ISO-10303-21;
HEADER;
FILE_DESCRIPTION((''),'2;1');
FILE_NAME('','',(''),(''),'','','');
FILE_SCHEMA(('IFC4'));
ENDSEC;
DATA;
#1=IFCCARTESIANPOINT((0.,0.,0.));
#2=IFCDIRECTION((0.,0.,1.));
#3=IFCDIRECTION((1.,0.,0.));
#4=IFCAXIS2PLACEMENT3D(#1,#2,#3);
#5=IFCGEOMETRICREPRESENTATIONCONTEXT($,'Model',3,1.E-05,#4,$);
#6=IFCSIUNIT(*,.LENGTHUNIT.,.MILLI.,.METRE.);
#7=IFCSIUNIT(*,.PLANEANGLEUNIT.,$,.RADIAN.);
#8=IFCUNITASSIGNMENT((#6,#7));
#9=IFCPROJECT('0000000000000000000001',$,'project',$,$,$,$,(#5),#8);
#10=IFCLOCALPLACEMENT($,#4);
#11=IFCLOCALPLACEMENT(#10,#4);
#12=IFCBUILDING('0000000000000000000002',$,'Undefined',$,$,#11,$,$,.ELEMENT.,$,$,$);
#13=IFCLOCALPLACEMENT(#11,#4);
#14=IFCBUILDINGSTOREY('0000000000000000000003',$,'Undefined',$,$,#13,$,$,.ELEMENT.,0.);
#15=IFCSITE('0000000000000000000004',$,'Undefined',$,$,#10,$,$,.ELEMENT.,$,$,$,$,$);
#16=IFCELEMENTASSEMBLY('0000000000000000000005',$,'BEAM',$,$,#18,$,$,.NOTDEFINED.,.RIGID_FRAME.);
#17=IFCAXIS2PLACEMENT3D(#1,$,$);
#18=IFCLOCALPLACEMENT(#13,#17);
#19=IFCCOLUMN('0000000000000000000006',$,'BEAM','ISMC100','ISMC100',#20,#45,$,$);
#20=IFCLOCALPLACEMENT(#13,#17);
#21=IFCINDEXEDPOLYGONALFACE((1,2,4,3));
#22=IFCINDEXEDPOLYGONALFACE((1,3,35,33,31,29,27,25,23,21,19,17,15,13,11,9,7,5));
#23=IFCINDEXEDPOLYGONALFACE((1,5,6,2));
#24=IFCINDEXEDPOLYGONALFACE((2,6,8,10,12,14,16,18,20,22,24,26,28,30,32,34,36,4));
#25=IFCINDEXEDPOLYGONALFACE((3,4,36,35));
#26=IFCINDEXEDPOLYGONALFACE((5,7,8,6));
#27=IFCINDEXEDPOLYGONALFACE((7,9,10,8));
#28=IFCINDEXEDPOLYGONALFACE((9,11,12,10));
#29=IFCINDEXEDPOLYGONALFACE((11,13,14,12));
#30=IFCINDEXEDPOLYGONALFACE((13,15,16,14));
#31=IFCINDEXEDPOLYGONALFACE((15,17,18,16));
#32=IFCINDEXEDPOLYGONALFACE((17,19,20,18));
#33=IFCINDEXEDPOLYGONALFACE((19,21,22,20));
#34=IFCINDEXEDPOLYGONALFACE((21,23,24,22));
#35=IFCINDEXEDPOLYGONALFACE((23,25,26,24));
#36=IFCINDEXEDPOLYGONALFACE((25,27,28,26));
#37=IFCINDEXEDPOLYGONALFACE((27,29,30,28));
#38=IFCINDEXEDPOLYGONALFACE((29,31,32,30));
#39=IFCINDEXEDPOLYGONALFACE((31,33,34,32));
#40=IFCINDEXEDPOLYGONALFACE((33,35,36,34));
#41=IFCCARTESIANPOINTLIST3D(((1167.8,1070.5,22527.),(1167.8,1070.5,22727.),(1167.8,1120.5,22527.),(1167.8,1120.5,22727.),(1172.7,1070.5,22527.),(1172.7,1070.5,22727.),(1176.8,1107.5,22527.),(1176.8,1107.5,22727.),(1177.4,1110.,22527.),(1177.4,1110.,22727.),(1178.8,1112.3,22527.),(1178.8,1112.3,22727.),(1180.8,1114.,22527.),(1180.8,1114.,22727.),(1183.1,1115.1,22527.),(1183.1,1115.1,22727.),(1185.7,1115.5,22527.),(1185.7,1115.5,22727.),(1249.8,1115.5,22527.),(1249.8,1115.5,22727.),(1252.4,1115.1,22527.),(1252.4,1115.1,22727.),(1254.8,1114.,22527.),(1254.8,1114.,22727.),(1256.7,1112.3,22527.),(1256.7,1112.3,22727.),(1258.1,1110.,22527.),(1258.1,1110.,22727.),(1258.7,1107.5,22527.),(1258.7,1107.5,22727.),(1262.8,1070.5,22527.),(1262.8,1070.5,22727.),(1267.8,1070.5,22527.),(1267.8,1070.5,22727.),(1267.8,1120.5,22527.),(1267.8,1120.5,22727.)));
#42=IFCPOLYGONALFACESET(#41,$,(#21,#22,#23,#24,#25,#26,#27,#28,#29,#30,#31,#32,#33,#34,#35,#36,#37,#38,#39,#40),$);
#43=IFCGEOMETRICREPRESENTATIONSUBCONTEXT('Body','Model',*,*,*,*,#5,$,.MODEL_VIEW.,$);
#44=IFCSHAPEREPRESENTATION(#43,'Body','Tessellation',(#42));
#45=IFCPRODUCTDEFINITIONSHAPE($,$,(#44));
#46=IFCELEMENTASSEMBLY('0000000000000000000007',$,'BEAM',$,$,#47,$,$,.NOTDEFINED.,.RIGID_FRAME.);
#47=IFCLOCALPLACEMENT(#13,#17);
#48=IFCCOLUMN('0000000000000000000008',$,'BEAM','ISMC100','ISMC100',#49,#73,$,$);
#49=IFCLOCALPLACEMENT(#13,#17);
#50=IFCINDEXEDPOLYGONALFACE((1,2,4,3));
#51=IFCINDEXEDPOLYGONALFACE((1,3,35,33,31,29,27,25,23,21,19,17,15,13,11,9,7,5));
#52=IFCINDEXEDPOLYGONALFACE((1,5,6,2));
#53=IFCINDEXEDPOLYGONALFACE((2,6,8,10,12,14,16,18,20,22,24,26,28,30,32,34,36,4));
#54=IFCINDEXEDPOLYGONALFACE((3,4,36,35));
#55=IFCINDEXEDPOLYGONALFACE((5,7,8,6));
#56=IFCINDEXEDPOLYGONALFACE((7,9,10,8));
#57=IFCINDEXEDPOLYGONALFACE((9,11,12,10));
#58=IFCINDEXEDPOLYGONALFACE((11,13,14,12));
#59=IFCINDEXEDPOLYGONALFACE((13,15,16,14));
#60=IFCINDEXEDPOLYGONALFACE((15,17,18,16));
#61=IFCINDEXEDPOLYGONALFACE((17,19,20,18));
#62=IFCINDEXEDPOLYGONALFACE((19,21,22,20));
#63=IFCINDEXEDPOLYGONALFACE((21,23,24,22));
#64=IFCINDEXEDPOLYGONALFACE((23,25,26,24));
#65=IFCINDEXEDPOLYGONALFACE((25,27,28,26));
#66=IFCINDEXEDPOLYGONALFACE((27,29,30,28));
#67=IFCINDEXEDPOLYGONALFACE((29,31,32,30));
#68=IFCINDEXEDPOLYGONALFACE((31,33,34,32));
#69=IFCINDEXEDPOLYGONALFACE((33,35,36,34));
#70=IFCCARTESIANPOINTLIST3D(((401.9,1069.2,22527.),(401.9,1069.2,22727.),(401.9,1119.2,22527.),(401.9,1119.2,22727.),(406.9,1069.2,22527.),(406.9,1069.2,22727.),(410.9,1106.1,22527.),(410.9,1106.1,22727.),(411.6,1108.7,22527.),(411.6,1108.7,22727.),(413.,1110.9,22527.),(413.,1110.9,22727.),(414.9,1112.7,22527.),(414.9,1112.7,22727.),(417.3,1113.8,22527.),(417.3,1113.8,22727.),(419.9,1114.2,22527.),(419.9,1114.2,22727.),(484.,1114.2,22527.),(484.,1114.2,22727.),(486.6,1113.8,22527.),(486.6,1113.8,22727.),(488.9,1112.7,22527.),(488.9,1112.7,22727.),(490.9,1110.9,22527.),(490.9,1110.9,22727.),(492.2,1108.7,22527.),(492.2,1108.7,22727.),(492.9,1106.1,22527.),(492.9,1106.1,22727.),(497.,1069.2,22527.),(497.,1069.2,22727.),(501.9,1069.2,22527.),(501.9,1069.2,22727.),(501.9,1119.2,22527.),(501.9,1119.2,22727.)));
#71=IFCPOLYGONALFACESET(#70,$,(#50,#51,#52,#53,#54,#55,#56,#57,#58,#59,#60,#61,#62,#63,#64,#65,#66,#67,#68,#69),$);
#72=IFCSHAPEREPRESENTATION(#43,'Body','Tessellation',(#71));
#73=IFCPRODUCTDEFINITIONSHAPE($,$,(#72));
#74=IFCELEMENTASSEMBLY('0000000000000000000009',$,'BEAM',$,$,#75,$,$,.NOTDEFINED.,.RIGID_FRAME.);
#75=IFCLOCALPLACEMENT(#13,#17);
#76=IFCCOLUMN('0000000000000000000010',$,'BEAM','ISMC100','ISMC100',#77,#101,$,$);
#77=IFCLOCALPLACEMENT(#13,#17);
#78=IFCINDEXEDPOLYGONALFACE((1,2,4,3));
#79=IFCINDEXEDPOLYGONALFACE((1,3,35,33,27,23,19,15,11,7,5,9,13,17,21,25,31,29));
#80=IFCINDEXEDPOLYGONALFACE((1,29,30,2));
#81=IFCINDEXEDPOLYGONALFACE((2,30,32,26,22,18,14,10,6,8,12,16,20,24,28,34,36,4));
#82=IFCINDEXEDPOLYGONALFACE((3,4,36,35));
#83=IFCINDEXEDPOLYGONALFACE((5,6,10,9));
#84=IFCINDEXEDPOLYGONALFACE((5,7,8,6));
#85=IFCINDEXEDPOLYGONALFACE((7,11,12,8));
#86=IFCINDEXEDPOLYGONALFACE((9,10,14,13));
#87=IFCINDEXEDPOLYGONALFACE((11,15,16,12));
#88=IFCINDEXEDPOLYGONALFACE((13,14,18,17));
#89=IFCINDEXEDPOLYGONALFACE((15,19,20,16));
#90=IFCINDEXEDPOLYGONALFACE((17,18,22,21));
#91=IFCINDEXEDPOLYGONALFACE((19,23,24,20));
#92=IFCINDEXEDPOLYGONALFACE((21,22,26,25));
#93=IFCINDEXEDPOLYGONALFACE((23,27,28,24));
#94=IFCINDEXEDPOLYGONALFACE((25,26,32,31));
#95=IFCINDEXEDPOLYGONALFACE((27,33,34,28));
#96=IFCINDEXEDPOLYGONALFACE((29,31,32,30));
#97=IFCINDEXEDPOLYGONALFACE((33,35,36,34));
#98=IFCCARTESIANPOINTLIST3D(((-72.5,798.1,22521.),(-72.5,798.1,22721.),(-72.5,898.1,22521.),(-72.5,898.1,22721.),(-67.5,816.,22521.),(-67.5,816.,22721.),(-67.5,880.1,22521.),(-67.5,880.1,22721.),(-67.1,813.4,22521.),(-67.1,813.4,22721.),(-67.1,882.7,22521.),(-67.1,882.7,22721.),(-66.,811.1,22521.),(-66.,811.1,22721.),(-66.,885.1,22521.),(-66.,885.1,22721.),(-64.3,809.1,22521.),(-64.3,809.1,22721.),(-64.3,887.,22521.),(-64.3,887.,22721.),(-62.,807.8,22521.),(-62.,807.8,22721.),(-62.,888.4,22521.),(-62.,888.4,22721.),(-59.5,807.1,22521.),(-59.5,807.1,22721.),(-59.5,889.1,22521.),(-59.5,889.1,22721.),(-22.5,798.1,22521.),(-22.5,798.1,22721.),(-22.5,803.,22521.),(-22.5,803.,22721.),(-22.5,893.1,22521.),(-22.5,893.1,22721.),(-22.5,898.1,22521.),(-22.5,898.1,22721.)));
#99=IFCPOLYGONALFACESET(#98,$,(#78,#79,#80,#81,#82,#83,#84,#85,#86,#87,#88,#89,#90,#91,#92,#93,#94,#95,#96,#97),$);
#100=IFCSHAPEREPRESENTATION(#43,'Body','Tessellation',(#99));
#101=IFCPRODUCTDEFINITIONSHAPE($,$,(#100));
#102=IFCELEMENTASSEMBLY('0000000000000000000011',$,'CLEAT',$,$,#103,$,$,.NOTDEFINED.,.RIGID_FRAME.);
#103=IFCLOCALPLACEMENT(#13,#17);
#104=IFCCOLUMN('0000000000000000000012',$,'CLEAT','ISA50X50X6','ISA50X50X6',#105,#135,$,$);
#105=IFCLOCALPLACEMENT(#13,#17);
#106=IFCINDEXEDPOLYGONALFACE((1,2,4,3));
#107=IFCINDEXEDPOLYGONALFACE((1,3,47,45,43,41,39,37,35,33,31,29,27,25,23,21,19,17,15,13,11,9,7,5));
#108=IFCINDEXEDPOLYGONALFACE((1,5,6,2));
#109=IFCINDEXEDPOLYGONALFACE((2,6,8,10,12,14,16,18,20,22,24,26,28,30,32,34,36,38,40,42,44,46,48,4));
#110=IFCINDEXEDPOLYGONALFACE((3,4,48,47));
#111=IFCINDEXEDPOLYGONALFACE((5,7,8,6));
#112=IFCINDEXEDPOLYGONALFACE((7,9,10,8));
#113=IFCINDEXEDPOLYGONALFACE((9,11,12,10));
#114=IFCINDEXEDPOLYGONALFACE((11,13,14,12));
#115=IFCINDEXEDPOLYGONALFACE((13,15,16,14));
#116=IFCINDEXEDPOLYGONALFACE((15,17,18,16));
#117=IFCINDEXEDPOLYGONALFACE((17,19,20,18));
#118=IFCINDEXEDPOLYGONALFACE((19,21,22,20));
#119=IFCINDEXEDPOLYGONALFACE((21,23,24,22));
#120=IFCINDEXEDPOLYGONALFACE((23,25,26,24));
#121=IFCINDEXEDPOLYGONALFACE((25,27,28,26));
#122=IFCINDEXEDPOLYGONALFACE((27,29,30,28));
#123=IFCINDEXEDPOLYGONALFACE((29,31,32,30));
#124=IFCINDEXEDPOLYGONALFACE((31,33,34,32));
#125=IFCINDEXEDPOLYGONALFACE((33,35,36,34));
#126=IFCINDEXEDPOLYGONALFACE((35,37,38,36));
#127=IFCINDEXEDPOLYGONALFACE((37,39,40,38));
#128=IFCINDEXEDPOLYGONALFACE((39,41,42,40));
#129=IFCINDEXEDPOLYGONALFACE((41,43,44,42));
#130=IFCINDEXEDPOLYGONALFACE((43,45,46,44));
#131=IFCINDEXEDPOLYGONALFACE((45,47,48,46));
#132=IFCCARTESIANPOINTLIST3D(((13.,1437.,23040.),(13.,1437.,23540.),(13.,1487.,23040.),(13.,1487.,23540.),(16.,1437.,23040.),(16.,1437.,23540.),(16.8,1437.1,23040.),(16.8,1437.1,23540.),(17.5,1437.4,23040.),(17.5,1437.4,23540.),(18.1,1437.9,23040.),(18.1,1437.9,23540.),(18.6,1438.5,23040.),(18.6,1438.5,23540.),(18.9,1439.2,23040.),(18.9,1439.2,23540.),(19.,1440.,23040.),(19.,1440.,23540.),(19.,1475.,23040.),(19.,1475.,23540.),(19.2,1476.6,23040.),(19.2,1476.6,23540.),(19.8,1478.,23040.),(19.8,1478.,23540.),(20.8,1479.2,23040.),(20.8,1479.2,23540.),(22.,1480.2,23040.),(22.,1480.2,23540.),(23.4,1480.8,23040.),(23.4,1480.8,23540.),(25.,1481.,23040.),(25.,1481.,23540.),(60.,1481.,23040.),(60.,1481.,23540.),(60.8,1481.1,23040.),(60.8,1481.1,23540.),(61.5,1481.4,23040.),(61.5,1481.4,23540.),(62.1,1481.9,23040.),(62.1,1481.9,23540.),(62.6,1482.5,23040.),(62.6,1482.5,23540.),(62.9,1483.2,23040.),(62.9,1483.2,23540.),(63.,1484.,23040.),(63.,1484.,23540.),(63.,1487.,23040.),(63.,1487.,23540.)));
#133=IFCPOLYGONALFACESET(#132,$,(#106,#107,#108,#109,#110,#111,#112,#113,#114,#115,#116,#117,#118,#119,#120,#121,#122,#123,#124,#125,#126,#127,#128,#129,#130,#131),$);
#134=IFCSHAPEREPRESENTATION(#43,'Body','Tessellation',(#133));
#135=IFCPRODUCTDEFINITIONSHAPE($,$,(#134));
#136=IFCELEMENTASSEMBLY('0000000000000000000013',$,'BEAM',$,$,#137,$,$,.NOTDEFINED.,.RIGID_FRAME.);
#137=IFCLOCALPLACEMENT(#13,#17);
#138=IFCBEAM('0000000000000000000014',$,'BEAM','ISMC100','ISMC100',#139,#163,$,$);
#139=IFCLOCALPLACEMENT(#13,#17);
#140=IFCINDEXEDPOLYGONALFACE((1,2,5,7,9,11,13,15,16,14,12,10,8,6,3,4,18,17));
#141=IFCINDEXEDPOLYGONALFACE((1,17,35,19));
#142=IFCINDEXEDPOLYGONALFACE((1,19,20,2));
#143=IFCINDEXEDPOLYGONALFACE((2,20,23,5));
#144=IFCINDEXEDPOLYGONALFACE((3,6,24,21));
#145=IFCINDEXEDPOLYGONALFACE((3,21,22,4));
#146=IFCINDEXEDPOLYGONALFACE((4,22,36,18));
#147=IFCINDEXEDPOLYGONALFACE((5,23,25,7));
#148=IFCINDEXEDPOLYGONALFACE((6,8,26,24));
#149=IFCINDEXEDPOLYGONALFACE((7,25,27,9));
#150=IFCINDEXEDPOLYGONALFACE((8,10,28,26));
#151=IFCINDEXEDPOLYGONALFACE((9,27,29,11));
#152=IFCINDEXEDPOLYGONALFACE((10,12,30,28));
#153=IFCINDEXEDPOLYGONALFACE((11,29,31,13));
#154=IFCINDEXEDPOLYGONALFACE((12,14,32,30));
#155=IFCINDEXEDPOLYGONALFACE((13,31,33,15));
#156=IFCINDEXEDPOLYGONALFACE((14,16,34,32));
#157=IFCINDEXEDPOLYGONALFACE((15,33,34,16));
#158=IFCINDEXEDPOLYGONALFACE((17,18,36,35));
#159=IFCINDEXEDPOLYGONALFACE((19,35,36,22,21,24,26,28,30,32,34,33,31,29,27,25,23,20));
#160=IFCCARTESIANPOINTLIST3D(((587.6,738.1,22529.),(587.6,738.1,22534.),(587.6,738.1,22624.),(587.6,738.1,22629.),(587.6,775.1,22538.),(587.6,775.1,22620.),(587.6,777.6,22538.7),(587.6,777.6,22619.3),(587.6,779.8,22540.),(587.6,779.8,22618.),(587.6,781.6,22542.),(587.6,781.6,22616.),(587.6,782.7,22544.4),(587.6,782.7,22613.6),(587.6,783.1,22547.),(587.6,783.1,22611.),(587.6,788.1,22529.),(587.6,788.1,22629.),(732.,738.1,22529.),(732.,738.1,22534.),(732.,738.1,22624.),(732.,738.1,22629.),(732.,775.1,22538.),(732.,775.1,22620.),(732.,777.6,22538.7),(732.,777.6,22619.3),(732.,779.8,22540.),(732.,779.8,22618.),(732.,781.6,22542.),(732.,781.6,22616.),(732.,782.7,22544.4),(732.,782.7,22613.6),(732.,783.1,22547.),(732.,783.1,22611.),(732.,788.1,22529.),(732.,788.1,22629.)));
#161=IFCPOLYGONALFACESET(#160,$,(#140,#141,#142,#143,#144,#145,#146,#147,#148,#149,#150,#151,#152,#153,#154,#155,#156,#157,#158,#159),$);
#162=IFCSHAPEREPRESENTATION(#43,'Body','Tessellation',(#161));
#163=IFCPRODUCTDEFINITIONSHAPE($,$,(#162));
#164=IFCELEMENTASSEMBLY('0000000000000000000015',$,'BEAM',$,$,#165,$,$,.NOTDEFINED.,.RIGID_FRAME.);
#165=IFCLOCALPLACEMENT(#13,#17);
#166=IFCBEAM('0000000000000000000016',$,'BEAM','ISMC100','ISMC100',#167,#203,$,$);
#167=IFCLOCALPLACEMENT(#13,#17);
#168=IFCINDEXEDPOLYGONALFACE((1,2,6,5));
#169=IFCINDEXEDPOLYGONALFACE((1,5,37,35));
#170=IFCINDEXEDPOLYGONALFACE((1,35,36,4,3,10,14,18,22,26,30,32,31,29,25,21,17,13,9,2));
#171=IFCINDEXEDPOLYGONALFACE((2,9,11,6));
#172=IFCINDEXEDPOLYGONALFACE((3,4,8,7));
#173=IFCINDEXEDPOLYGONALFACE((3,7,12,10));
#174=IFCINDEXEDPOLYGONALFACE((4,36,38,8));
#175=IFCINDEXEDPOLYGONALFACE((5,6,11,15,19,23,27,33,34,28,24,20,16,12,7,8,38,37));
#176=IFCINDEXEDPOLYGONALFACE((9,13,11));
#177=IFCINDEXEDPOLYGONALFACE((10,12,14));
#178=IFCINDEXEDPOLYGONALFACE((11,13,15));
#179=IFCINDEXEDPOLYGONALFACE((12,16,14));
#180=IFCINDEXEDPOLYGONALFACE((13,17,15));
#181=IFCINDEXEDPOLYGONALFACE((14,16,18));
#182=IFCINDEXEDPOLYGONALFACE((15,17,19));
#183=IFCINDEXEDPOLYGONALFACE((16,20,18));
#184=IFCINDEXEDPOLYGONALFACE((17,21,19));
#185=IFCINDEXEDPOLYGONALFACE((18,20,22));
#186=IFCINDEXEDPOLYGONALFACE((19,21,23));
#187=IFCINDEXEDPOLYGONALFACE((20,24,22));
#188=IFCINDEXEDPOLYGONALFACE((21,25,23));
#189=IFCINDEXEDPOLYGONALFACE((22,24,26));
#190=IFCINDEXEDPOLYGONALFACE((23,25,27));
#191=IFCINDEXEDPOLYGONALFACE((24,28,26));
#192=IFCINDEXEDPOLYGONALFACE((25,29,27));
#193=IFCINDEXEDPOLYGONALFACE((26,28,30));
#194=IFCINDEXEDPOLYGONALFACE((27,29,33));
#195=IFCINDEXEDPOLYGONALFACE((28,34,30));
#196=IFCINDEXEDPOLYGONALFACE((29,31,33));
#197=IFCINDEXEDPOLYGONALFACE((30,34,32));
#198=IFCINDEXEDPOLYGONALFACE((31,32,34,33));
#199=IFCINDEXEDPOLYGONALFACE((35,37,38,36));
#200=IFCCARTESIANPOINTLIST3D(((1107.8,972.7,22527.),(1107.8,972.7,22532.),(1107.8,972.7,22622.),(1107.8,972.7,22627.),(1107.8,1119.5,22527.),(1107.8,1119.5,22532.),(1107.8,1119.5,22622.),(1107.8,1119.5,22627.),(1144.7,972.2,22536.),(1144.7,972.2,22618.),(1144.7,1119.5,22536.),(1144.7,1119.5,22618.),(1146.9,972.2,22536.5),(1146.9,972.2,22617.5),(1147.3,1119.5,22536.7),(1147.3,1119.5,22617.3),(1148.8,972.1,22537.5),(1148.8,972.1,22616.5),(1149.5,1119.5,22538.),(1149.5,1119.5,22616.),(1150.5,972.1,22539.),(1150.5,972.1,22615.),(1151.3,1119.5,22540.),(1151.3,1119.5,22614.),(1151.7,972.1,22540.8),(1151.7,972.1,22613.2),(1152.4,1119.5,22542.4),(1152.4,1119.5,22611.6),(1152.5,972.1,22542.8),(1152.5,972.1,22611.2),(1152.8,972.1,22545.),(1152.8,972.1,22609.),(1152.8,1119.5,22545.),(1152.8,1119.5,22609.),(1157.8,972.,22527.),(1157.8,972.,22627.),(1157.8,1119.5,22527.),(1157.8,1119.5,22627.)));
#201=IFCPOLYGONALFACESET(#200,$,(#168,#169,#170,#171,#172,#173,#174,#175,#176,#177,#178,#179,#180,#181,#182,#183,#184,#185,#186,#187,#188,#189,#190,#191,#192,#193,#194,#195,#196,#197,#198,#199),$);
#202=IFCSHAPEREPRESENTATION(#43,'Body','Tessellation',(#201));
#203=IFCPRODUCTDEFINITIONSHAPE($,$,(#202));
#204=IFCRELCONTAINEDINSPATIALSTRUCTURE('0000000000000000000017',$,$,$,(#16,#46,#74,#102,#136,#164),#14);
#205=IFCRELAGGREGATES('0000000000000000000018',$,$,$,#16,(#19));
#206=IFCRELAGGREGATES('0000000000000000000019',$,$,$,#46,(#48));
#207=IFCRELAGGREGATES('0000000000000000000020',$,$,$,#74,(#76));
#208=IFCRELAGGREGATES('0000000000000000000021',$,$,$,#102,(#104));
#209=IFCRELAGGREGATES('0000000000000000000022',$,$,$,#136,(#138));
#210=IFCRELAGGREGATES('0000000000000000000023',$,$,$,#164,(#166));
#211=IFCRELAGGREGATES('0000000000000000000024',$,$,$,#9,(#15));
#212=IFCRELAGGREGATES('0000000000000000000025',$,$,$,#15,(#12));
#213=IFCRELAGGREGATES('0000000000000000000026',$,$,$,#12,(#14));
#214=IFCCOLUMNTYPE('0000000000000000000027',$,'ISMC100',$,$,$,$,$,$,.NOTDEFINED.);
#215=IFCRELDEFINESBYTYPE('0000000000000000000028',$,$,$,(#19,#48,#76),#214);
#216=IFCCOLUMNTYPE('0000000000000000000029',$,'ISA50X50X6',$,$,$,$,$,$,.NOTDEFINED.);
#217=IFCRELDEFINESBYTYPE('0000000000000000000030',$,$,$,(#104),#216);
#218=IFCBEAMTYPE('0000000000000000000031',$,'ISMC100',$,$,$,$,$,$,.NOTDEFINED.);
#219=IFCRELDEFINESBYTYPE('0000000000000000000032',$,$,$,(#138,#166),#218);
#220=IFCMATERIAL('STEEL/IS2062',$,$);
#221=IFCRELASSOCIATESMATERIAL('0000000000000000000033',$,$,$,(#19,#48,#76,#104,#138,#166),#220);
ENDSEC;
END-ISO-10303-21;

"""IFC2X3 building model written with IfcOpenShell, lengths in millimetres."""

from ifc_helpers import new_model, si_unit, frame, origin_with_axes, origin_2d_with_axis, place, context, subcontext, project, spatial, l_section, u_section, extrude, clip, halfspace, material, type_object, element, aggregate, save


model = new_model("IFC2X3")

# Units and contexts
model_context = context("Model", 3, precision=1e-05, world=origin_with_axes())
body_context = subcontext(model_context, "Body", "Model", "MODEL_VIEW")
ifc_project = project(units=[si_unit("LENGTHUNIT", "METRE", prefix="MILLI"), si_unit("PLANEANGLEUNIT", "RADIAN")], contexts=[model_context])

# Site, building, storey
site_placement = place(None, origin_with_axes())
site = spatial("IfcSite", under=ifc_project, at=site_placement, Name="Undefined", CompositionType="ELEMENT")
building_placement = place(site_placement, origin_with_axes())
building = spatial("IfcBuilding", under=site, at=building_placement, Name="Undefined", CompositionType="ELEMENT")
storey_placement = place(building_placement, origin_with_axes())
storey = spatial("IfcBuildingStorey", under=building, at=storey_placement, Name="Undefined", CompositionType="ELEMENT", Elevation=0.0)

# Element assemblies, columns
assembly_1_placement = place(storey_placement, origin_with_axes())
assembly_1 = element("IfcElementAssembly", 1, at=assembly_1_placement, inside=storey, Name="BEAM", AssemblyPlace="NOTDEFINED", PredefinedType="RIGID_FRAME")
ifc_material = material(Name="STEEL/IS2062")
column_type_1 = type_object("IfcColumnType", Name="ISMC100", PredefinedType="NOTDEFINED")
column_1_placement = place(assembly_1_placement, frame((1217.8, 1095.5, 22527.0), z_axis=(0.0, 0.0, 1.0), x_axis=(-1.0, 0.0, 0.0)))
column_1 = element("IfcColumn", 2, at=column_1_placement, type_object=column_type_1, material=ifc_material, Name="BEAM", Description="ISMC100", ObjectType="ISMC100", context=body_context, shape_type="SweptSolid", body=[
    extrude(u_section(Depth=100.0, FlangeWidth=50.0, WebThickness=5.0, FlangeThickness=7.7, FilletRadius=9.0, FlangeSlope=0.10956, at=origin_2d_with_axis()), frame((0.0, 0.0, 200.0), z_axis=(0.0, 0.0, -1.0), x_axis=(0.0, 1.0, 0.0)), (0.0, 0.0, 1.0), 200.0),
])
aggregate(assembly_1, [column_1])
assembly_2_placement = place(storey_placement, origin_with_axes())
assembly_2 = element("IfcElementAssembly", 3, at=assembly_2_placement, inside=storey, Name="BEAM", AssemblyPlace="NOTDEFINED", PredefinedType="RIGID_FRAME")
column_2_placement = place(assembly_2_placement, frame((451.9, 1094.2, 22527.0), z_axis=(0.0, 0.0, 1.0), x_axis=(-1.0, 0.0, 0.0)))
column_2 = element("IfcColumn", 4, at=column_2_placement, type_object=column_type_1, material=ifc_material, Name="BEAM", Description="ISMC100", ObjectType="ISMC100", context=body_context, shape_type="SweptSolid", body=[
    extrude(u_section(Depth=100.0, FlangeWidth=50.0, WebThickness=5.0, FlangeThickness=7.7, FilletRadius=9.0, FlangeSlope=0.10956, at=origin_2d_with_axis()), frame((0.0, 0.0, 200.0), z_axis=(0.0, 0.0, -1.0), x_axis=(0.0, 1.0, 0.0)), (0.0, 0.0, 1.0), 200.0),
])
aggregate(assembly_2, [column_2])
assembly_3_placement = place(storey_placement, origin_with_axes())
assembly_3 = element("IfcElementAssembly", 5, at=assembly_3_placement, inside=storey, Name="BEAM", AssemblyPlace="NOTDEFINED", PredefinedType="RIGID_FRAME")
column_3_placement = place(assembly_3_placement, frame((-47.5, 848.1, 22521.0), z_axis=(0.0, 0.0, 1.0), x_axis=(0.0, -1.0, 0.0)))
column_3 = element("IfcColumn", 6, at=column_3_placement, type_object=column_type_1, material=ifc_material, Name="BEAM", Description="ISMC100", ObjectType="ISMC100", context=body_context, shape_type="SweptSolid", body=[
    extrude(u_section(Depth=100.0, FlangeWidth=50.0, WebThickness=5.0, FlangeThickness=7.7, FilletRadius=9.0, FlangeSlope=0.10956, at=origin_2d_with_axis()), frame((0.0, 0.0, 200.0), z_axis=(0.0, 0.0, -1.0), x_axis=(0.0, 1.0, 0.0)), (0.0, 0.0, 1.0), 200.0),
])
aggregate(assembly_3, [column_3])
assembly_4_placement = place(storey_placement, origin_with_axes())
assembly_4 = element("IfcElementAssembly", 7, at=assembly_4_placement, inside=storey, Name="CLEAT", AssemblyPlace="NOTDEFINED", PredefinedType="RIGID_FRAME")
column_type_2 = type_object("IfcColumnType", Name="ISA50X50X6", PredefinedType="NOTDEFINED")
column_4_placement = place(assembly_4_placement, frame((38.0, 1462.0, 23040.0), z_axis=(0.0, 0.0, 1.0), x_axis=(0.0, -1.0, 0.0)))
column_4 = element("IfcColumn", 8, at=column_4_placement, type_object=column_type_2, material=ifc_material, Name="CLEAT", Description="ISA50X50X6", ObjectType="ISA50X50X6", context=body_context, shape_type="SweptSolid", body=[
    extrude(l_section(Depth=50.0, Width=50.0, Thickness=6.0, FilletRadius=6.0, EdgeRadius=3.0, at=origin_2d_with_axis()), frame((0.0, 0.0, 500.0), z_axis=(0.0, 0.0, -1.0), x_axis=(0.0, 1.0, 0.0)), (0.0, 0.0, 1.0), 500.0),
])
aggregate(assembly_4, [column_4])

# Element assemblies, beams
assembly_5_placement = place(storey_placement, origin_with_axes())
assembly_5 = element("IfcElementAssembly", 9, at=assembly_5_placement, inside=storey, Name="BEAM", AssemblyPlace="NOTDEFINED", PredefinedType="RIGID_FRAME")
beam_type_1 = type_object("IfcBeamType", Name="ISMC100", PredefinedType="NOTDEFINED")
beam_1_placement = place(assembly_5_placement, frame((732.0, 763.1, 22579.0), z_axis=(0.0, 0.0, -1.0), x_axis=(-1.0, 0.0, 0.0)))
beam_1 = element("IfcBeam", 10, at=beam_1_placement, type_object=beam_type_1, material=ifc_material, Name="BEAM", Description="ISMC100", ObjectType="ISMC100", context=body_context, shape_type="SweptSolid", body=[
    extrude(u_section(Depth=100.0, FlangeWidth=50.0, WebThickness=5.0, FlangeThickness=7.7, FilletRadius=9.0, FlangeSlope=0.10956, at=origin_2d_with_axis()), frame((144.4, 0.0, 0.0), z_axis=(-1.0, 0.0, 0.0), x_axis=(0.0, -1.0, 0.0)), (0.0, 0.0, 1.0), 144.4),
])
aggregate(assembly_5, [beam_1])
assembly_6_placement = place(storey_placement, origin_with_axes())
assembly_6 = element("IfcElementAssembly", 11, at=assembly_6_placement, inside=storey, Name="BEAM", AssemblyPlace="NOTDEFINED", PredefinedType="RIGID_FRAME")
beam_2_placement = place(assembly_6_placement, frame((1132.8, 972.0, 22577.0), z_axis=(0.0, 0.0, -1.0), x_axis=(0.0, 1.0, 0.0)))
beam_2 = element("IfcBeam", 12, at=beam_2_placement, type_object=beam_type_1, material=ifc_material, Name="BEAM", Description="ISMC100", ObjectType="ISMC100", context=body_context, shape_type="Clipping", body=[
    clip(extrude(u_section(Depth=100.0, FlangeWidth=50.0, WebThickness=5.0, FlangeThickness=7.7, FilletRadius=9.0, FlangeSlope=0.10956, at=origin_2d_with_axis()), frame((147.5, 0.0, 0.0), z_axis=(-1.0, 0.0, 0.0), x_axis=(0.0, -1.0, 0.0)), (0.0, 0.0, 1.0), 147.5), halfspace(frame((0.0, 25.0, -50.0), z_axis=(-0.999902, -0.013997, 0.0), x_axis=(0.0, 0.0, 1.0)), False)),
])
aggregate(assembly_6, [beam_2])

save(model, "model.ifc")
